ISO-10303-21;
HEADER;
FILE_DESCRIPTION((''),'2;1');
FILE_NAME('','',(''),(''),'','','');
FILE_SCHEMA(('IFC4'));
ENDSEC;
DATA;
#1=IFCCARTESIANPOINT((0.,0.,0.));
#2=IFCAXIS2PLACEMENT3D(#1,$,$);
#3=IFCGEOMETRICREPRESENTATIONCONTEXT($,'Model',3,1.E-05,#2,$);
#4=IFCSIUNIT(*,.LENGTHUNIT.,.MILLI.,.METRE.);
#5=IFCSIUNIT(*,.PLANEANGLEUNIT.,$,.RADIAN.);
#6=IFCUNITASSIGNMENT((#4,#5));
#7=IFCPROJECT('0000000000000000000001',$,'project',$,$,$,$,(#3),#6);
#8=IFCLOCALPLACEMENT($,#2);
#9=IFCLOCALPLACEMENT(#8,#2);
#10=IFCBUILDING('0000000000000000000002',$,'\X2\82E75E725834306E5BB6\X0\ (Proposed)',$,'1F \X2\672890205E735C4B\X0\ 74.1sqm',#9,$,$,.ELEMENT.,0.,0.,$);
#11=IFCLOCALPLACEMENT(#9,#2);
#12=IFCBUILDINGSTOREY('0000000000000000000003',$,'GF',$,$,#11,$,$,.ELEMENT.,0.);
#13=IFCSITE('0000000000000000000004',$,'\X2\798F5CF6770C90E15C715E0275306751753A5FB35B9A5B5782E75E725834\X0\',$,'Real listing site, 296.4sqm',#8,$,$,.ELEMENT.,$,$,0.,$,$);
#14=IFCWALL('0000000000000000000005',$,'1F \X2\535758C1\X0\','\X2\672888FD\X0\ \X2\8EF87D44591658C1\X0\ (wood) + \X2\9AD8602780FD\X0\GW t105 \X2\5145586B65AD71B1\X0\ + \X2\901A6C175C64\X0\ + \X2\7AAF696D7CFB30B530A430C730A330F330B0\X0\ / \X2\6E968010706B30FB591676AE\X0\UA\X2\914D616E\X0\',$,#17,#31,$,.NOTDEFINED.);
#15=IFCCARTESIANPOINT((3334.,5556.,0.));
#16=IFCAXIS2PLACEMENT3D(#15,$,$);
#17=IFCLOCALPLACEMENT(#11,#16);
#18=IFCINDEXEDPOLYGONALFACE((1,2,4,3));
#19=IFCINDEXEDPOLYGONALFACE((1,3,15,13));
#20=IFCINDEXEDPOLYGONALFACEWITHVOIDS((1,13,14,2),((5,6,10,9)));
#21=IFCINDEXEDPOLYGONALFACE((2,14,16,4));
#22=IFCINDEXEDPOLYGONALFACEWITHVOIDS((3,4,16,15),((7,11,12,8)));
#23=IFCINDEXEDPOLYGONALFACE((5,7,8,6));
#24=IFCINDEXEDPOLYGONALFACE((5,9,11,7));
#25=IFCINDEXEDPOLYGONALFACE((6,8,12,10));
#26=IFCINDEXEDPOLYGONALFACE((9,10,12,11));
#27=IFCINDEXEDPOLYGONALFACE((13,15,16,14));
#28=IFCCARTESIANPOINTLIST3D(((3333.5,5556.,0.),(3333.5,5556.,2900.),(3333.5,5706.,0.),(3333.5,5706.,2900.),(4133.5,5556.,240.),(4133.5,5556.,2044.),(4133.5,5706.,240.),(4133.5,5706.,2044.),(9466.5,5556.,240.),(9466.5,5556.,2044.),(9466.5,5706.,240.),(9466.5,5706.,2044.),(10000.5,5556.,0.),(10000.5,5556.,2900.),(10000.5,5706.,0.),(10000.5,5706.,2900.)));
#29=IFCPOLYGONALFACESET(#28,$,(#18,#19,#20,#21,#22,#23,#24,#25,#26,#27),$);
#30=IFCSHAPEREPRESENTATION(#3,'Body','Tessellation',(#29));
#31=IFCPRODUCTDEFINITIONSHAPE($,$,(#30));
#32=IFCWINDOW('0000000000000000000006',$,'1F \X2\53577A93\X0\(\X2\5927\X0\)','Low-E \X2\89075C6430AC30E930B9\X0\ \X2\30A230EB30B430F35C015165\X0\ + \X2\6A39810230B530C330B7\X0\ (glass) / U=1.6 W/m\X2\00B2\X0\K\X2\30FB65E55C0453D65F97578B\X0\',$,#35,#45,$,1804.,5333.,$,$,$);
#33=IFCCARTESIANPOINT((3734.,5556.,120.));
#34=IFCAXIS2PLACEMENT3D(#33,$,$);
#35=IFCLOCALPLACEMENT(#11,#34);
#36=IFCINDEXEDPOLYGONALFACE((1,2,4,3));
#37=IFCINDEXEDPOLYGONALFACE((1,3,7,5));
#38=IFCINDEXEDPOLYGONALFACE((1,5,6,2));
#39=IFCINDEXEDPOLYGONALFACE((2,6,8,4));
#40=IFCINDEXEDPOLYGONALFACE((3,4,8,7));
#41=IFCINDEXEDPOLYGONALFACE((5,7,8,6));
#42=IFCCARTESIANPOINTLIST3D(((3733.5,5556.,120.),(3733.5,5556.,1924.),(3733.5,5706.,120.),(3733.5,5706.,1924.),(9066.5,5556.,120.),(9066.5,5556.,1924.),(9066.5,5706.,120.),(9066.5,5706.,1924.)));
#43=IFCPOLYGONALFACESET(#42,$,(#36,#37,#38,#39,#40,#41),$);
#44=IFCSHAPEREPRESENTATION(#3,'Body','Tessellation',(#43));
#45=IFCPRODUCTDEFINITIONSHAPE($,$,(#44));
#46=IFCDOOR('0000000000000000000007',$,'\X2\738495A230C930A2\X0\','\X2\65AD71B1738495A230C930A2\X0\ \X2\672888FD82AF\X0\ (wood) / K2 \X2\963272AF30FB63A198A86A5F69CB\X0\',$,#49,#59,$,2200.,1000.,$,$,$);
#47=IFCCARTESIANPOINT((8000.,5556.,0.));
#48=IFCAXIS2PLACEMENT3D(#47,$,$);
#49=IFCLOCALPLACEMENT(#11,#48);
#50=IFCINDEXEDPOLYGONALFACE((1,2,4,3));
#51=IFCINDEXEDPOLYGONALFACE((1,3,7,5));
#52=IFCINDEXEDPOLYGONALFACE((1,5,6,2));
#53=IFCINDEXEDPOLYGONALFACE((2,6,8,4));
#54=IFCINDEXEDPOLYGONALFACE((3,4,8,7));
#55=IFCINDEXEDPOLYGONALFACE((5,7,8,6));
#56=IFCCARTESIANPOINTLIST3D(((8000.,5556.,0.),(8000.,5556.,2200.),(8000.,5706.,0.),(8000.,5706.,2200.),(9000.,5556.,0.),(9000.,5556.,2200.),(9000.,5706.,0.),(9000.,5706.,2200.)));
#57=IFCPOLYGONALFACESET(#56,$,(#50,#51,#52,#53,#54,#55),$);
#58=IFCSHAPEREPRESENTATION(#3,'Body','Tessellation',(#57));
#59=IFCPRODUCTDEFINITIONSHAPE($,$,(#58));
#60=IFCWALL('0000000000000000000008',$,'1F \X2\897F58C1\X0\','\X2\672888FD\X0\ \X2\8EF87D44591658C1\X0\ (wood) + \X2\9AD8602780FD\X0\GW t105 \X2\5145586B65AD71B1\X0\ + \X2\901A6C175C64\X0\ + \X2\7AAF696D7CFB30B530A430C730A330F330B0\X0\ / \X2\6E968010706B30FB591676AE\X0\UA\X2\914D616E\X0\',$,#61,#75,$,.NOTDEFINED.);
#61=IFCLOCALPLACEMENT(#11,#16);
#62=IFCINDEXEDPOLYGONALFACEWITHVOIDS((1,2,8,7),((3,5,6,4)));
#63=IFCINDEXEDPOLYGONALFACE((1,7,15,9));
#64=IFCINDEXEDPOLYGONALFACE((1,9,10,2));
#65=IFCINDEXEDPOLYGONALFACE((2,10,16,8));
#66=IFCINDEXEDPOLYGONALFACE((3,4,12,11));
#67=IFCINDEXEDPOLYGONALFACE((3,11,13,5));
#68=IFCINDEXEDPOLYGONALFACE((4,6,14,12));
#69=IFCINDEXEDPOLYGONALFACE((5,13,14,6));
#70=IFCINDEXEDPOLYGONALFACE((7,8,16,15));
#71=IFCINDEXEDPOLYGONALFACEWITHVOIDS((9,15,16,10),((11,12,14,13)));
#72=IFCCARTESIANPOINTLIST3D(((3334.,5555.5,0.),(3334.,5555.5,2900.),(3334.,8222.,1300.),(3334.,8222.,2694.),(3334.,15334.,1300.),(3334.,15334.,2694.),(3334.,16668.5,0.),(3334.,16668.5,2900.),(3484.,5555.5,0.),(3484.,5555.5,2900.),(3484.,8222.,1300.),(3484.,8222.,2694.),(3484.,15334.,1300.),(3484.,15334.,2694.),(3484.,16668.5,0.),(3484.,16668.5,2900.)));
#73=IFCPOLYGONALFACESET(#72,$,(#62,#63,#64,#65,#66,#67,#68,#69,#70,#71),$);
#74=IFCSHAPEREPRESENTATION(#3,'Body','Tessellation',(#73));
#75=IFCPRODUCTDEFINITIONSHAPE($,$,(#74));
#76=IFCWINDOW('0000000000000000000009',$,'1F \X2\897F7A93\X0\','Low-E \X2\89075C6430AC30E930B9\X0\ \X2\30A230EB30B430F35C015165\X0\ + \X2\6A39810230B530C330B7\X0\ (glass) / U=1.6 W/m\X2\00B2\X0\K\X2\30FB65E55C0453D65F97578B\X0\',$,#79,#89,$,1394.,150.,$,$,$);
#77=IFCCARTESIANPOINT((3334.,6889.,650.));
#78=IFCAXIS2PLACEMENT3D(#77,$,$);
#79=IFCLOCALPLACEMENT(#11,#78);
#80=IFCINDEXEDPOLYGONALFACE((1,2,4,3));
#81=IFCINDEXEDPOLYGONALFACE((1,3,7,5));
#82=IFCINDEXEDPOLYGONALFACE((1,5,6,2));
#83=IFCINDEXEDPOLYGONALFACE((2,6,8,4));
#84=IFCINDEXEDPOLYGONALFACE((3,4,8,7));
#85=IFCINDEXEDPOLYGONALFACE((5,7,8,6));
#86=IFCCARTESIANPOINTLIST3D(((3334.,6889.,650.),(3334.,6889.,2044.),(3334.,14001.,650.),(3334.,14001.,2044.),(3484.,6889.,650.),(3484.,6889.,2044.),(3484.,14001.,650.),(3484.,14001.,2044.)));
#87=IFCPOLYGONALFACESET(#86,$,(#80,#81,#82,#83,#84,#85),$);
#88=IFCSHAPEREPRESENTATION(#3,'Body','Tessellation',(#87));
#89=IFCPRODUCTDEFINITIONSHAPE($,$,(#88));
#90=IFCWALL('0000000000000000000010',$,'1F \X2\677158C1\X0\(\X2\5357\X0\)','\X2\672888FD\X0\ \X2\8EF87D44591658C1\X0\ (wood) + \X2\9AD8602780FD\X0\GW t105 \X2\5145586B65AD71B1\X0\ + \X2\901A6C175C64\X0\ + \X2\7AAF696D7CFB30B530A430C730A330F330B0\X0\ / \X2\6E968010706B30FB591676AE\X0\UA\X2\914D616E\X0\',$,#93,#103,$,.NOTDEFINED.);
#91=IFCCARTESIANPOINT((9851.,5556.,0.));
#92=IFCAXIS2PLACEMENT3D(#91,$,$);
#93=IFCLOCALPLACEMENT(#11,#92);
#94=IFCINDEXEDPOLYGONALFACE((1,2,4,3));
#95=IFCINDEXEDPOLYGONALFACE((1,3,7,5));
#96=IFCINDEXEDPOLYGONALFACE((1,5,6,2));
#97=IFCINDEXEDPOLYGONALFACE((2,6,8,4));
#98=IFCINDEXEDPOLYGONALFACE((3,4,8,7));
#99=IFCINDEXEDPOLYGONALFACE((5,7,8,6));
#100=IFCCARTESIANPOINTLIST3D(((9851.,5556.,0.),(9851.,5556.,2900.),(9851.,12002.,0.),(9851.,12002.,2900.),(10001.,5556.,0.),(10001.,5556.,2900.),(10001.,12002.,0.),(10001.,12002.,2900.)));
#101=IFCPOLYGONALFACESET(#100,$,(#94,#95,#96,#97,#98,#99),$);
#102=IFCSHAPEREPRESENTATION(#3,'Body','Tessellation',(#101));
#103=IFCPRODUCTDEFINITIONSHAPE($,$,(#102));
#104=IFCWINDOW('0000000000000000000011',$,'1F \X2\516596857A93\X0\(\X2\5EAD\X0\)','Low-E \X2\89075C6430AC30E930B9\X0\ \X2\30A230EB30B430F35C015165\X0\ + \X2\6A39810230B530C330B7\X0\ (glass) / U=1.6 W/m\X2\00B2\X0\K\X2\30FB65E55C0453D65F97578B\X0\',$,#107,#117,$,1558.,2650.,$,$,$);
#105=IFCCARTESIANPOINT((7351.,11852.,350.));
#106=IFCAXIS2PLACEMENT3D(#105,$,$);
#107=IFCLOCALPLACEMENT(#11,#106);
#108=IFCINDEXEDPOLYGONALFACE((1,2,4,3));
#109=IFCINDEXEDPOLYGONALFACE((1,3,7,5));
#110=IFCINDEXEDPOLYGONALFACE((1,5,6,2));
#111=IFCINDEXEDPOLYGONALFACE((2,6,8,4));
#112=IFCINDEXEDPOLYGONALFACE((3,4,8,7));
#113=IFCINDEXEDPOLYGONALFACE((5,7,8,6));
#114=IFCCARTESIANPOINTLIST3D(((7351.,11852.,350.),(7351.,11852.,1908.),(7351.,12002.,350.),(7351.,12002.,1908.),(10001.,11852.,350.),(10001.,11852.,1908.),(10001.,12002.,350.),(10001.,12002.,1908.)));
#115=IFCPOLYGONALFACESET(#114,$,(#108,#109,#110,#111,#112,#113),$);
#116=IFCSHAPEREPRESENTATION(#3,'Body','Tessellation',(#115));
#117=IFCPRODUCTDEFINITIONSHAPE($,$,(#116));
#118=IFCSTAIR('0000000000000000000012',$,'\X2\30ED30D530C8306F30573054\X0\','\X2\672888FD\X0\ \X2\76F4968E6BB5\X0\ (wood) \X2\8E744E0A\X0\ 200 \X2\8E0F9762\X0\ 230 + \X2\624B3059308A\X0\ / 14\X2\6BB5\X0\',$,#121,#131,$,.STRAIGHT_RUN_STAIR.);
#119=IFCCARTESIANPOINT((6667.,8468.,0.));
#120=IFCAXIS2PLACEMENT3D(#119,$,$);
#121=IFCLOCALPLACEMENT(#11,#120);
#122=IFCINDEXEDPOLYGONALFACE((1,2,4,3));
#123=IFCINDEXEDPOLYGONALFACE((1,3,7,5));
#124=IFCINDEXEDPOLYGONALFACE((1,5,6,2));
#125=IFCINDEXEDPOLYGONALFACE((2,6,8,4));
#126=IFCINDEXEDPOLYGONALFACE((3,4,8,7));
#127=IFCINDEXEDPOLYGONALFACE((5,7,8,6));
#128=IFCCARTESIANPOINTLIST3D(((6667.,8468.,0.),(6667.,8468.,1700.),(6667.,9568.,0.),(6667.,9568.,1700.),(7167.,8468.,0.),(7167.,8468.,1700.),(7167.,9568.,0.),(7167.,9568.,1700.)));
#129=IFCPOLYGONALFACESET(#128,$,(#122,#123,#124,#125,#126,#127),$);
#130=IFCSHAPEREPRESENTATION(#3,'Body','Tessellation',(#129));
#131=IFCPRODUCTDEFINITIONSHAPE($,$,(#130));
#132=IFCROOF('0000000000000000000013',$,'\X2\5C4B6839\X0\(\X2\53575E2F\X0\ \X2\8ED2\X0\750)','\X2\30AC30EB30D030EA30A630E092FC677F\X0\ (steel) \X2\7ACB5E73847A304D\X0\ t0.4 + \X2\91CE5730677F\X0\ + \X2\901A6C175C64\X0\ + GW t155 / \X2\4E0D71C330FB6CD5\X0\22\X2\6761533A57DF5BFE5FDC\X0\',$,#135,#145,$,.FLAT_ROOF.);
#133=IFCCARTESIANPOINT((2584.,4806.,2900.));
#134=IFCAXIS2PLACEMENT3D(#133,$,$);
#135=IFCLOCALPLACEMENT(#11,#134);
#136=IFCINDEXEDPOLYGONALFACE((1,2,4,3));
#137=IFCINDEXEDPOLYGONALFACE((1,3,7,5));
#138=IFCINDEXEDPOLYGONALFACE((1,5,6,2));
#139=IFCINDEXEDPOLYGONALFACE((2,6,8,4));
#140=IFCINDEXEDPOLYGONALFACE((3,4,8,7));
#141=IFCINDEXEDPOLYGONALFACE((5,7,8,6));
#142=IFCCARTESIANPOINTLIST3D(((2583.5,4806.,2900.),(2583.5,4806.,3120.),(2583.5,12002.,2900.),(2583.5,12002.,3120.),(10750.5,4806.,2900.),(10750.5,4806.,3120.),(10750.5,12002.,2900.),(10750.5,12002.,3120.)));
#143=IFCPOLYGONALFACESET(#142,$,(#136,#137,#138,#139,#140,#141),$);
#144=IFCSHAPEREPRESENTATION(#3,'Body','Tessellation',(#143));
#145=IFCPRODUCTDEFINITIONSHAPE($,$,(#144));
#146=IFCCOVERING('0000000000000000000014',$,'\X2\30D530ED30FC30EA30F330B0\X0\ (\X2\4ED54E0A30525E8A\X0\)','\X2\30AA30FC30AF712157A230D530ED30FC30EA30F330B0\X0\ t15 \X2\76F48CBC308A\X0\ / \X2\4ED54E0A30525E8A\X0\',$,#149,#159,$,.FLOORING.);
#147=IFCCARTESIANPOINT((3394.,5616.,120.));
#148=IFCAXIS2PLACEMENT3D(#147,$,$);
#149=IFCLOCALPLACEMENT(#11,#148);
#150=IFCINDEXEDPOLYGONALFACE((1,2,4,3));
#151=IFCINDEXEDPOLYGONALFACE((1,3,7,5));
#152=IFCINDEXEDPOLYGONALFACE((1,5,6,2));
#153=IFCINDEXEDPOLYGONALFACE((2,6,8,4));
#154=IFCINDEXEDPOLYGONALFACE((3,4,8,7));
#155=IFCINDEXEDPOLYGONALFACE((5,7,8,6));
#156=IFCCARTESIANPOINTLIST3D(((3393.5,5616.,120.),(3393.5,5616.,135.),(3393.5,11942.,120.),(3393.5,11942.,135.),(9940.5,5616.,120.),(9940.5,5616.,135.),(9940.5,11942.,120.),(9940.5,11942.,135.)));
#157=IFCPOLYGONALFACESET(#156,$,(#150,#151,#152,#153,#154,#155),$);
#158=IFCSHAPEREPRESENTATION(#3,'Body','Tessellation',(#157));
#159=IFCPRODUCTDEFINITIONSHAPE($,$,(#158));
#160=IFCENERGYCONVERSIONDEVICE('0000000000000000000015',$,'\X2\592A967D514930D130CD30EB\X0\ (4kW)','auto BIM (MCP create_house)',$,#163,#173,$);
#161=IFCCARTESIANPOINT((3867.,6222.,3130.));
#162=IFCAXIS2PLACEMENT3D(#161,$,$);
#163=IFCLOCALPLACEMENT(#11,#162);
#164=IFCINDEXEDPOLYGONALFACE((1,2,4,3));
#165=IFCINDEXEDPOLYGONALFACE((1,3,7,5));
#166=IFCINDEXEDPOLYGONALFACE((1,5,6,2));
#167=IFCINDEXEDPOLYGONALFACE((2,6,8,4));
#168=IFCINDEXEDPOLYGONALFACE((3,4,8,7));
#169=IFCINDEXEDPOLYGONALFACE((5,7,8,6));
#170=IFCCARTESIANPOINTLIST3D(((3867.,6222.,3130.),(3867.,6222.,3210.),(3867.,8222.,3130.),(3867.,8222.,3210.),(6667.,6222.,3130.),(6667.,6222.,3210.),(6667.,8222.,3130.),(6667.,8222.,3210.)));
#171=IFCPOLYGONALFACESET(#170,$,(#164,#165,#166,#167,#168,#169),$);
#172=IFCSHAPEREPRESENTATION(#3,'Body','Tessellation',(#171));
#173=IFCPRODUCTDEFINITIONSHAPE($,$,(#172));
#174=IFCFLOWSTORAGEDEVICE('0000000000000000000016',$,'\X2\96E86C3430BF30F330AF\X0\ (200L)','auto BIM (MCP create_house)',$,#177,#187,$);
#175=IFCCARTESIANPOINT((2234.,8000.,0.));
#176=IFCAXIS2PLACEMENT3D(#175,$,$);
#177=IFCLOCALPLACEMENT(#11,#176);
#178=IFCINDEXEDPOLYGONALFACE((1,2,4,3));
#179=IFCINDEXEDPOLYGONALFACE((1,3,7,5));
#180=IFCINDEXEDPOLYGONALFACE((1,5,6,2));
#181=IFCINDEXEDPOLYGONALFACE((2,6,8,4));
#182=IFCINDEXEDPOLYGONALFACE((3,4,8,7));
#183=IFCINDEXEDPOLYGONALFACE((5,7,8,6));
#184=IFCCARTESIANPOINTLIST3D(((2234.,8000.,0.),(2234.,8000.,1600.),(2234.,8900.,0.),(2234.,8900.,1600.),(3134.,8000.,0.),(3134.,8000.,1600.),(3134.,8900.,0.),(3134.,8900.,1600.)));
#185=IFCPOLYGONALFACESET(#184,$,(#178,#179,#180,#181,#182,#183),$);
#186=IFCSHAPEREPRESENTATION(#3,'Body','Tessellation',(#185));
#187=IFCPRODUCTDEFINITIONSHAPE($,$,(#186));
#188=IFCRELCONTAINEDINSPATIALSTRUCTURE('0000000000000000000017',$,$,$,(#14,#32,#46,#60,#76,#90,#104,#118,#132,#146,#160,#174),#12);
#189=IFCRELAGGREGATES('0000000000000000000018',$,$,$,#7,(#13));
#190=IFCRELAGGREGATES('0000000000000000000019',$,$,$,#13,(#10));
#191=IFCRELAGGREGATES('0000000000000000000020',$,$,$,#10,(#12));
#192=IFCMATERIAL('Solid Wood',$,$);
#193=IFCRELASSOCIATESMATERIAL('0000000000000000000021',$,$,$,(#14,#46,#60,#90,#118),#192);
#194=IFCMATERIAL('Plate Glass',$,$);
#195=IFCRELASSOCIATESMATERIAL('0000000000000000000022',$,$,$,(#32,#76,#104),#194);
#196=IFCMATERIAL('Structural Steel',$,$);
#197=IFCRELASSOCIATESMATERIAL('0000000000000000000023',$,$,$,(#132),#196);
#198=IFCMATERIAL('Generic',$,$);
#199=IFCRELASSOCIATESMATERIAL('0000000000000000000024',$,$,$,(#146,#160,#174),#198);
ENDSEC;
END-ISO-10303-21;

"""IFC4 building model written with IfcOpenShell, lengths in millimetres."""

from ifc_helpers import new_model, si_unit, frame, frame_2d, origin, place, context, project, spatial, rectangle, extrude, material, element, fill, save


model = new_model("IFC4")

# Units and contexts
model_context = context("Model", 3, precision=1e-05, world=origin())
ifc_project = project(units=[si_unit("LENGTHUNIT", "METRE", prefix="MILLI"), si_unit("PLANEANGLEUNIT", "RADIAN")], contexts=[model_context])

# Site, building, storey
site_placement = place(None, origin())
site = spatial("IfcSite", under=ifc_project, at=site_placement, Name="福島県郡山市田村町徳定字苧干場", ObjectType="Real listing site, 296.4sqm", CompositionType="ELEMENT", RefElevation=0.0)
building_placement = place(site_placement, origin())
building = spatial("IfcBuilding", under=site, at=building_placement, Name="苧干場の家 (Proposed)", ObjectType="1F 木造平屋 74.1sqm", CompositionType="ELEMENT", ElevationOfRefHeight=0.0, ElevationOfTerrain=0.0)
storey_placement = place(building_placement, origin())
storey = spatial("IfcBuildingStorey", under=building, at=storey_placement, Name="GF", CompositionType="ELEMENT", Elevation=0.0)

# Shared definitions
ifc_material_1 = material(Name="Solid Wood")

# Wall, openings, window, door
wall_1_placement = place(storey_placement, frame((3334.0, 5556.0, 0.0)))
wall_1 = element("IfcWall", 1, at=wall_1_placement, inside=storey, material=ifc_material_1, Name="1F 南壁", Description="木製 軸組外壁 (wood) + 高性能GW t105 充填断熱 + 通気層 + 窯業系サイディング / 準耐火・外皮UA配慮", PredefinedType="NOTDEFINED", context=model_context, shape_type="SweptSolid", body=[
    extrude(rectangle(XDim=6667.0, YDim=150.0, at=frame_2d((3333.0, 75.0))), frame((3334.0, 5556.0, 0.0)), (0.0, 0.0, 1.0), 2900.0),
])
opening_1_placement = place(storey_placement, frame((3734.0, 5556.0, 120.0)))
opening_1 = element("IfcOpeningElement", 2, at=opening_1_placement, cuts=wall_1, PredefinedType="NOTDEFINED", context=model_context, shape_type="SweptSolid", body=[
    extrude(rectangle(XDim=5333.0, YDim=150.0, at=frame_2d((2666.0, 75.0))), frame((3734.0, 5556.0, 120.0)), (0.0, 0.0, 1.0), 1804.0),
])
opening_2_placement = place(storey_placement, frame((8000.0, 5556.0, 0.0)))
opening_2 = element("IfcOpeningElement", 3, at=opening_2_placement, cuts=wall_1, PredefinedType="NOTDEFINED", context=model_context, shape_type="SweptSolid", body=[
    extrude(rectangle(XDim=1000.0, YDim=150.0, at=frame_2d((500.0, 75.0))), frame((8000.0, 5556.0, 0.0)), (0.0, 0.0, 1.0), 2200.0),
])
ifc_material_2 = material(Name="Plate Glass")
window_1_placement = place(storey_placement, frame((3734.0, 5556.0, 120.0)))
window_1 = element("IfcWindow", 4, at=window_1_placement, inside=storey, material=ifc_material_2, Name="1F 南窓(大)", Description="Low-E 複層ガラス アルゴン封入 + 樹脂サッシ (glass) / U=1.6 W/m²K・日射取得型", OverallHeight=1804.0, OverallWidth=5333.0, context=model_context, shape_type="SweptSolid", body=[
    extrude(rectangle(XDim=5333.0, YDim=150.0, at=frame_2d((2666.0, 75.0))), frame((3734.0, 5556.0, 120.0)), (0.0, 0.0, 1.0), 1804.0),
])
fill(opening_1, window_1)
door_1_placement = place(storey_placement, frame((8000.0, 5556.0, 0.0)))
door_1 = element("IfcDoor", 5, at=door_1_placement, inside=storey, material=ifc_material_1, Name="玄関ドア", Description="断熱玄関ドア 木製芯 (wood) / K2 防犯・採風機構", OverallHeight=2200.0, OverallWidth=1000.0, context=model_context, shape_type="SweptSolid", body=[
    extrude(rectangle(XDim=1000.0, YDim=150.0, at=frame_2d((500.0, 75.0))), frame((8000.0, 5556.0, 0.0)), (0.0, 0.0, 1.0), 2200.0),
])
fill(opening_2, door_1)

# Walls, openings, windows
wall_2_placement = place(storey_placement, frame((3334.0, 5556.0, 0.0)))
wall_2 = element("IfcWall", 6, at=wall_2_placement, inside=storey, material=ifc_material_1, Name="1F 西壁", Description="木製 軸組外壁 (wood) + 高性能GW t105 充填断熱 + 通気層 + 窯業系サイディング / 準耐火・外皮UA配慮", PredefinedType="NOTDEFINED", context=model_context, shape_type="SweptSolid", body=[
    extrude(rectangle(XDim=150.0, YDim=11113.0, at=frame_2d((75.0, 5556.0))), frame((3334.0, 5556.0, 0.0)), (0.0, 0.0, 1.0), 2900.0),
])
opening_3_placement = place(storey_placement, frame((3334.0, 6889.0, 650.0)))
opening_3 = element("IfcOpeningElement", 7, at=opening_3_placement, cuts=wall_2, PredefinedType="NOTDEFINED", context=model_context, shape_type="SweptSolid", body=[
    extrude(rectangle(XDim=150.0, YDim=7112.0, at=frame_2d((75.0, 3556.0))), frame((3334.0, 6889.0, 650.0)), (0.0, 0.0, 1.0), 1394.0),
])
window_2_placement = place(storey_placement, frame((3334.0, 6889.0, 650.0)))
window_2 = element("IfcWindow", 8, at=window_2_placement, inside=storey, material=ifc_material_2, Name="1F 西窓", Description="Low-E 複層ガラス アルゴン封入 + 樹脂サッシ (glass) / U=1.6 W/m²K・日射取得型", OverallHeight=1394.0, OverallWidth=150.0, context=model_context, shape_type="SweptSolid", body=[
    extrude(rectangle(XDim=150.0, YDim=7112.0, at=frame_2d((75.0, 3556.0))), frame((3334.0, 6889.0, 650.0)), (0.0, 0.0, 1.0), 1394.0),
])
fill(opening_3, window_2)
wall_3_placement = place(storey_placement, frame((9851.0, 5556.0, 0.0)))
wall_3 = element("IfcWall", 9, at=wall_3_placement, inside=storey, material=ifc_material_1, Name="1F 東壁(南)", Description="木製 軸組外壁 (wood) + 高性能GW t105 充填断熱 + 通気層 + 窯業系サイディング / 準耐火・外皮UA配慮", PredefinedType="NOTDEFINED", context=model_context, shape_type="SweptSolid", body=[
    extrude(rectangle(XDim=150.0, YDim=6446.0, at=frame_2d((75.0, 3223.0))), frame((9851.0, 5556.0, 0.0)), (0.0, 0.0, 1.0), 2900.0),
])
opening_4_placement = place(storey_placement, frame((7351.0, 11852.0, 350.0)))
opening_4 = element("IfcOpeningElement", 10, at=opening_4_placement, cuts=wall_3, PredefinedType="NOTDEFINED", context=model_context, shape_type="SweptSolid", body=[
    extrude(rectangle(XDim=2650.0, YDim=150.0, at=frame_2d((1325.0, 75.0))), frame((7351.0, 11852.0, 350.0)), (0.0, 0.0, 1.0), 1558.0),
])
window_3_placement = place(storey_placement, frame((7351.0, 11852.0, 350.0)))
window_3 = element("IfcWindow", 11, at=window_3_placement, inside=storey, material=ifc_material_2, Name="1F 入隅窓(庭)", Description="Low-E 複層ガラス アルゴン封入 + 樹脂サッシ (glass) / U=1.6 W/m²K・日射取得型", OverallHeight=1558.0, OverallWidth=2650.0, context=model_context, shape_type="SweptSolid", body=[
    extrude(rectangle(XDim=2650.0, YDim=150.0, at=frame_2d((1325.0, 75.0))), frame((7351.0, 11852.0, 350.0)), (0.0, 0.0, 1.0), 1558.0),
])
fill(opening_4, window_3)

# Stair
stair_placement = place(storey_placement, frame((6667.0, 8468.0, 0.0)))
element("IfcStair", 12, at=stair_placement, inside=storey, material=ifc_material_1, Name="ロフトはしご", Description="木製 直階段 (wood) 蹴上 200 踏面 230 + 手すり / 14段", PredefinedType="STRAIGHT_RUN_STAIR", context=model_context, shape_type="SweptSolid", body=[
    extrude(rectangle(XDim=500.0, YDim=1100.0, at=frame_2d((250.0, 550.0))), frame((6667.0, 8468.0, 0.0)), (0.0, 0.0, 1.0), 1700.0),
])

# Roof
ifc_material_3 = material(Name="Structural Steel")
roof_placement = place(storey_placement, frame((2584.0, 4806.0, 2900.0)))
element("IfcRoof", 13, at=roof_placement, inside=storey, material=ifc_material_3, Name="屋根(南帯 軒750)", Description="ガルバリウム鋼板 (steel) 立平葺き t0.4 + 野地板 + 通気層 + GW t155 / 不燃・法22条区域対応", PredefinedType="FLAT_ROOF", context=model_context, shape_type="SweptSolid", body=[
    extrude(rectangle(XDim=8167.0, YDim=7196.0, at=frame_2d((4083.0, 3598.0))), frame((2584.0, 4806.0, 2900.0)), (0.0, 0.0, 1.0), 220.0),
])

# Covering
ifc_material_4 = material(Name="Generic")
covering_placement = place(storey_placement, frame((3394.0, 5616.0, 120.0)))
element("IfcCovering", 14, at=covering_placement, inside=storey, material=ifc_material_4, Name="フローリング (仕上げ床)", Description="オーク無垢フローリング t15 直貼り / 仕上げ床", PredefinedType="FLOORING", context=model_context, shape_type="SweptSolid", body=[
    extrude(rectangle(XDim=6547.0, YDim=6326.0, at=frame_2d((3273.0, 3163.0))), frame((3394.0, 5616.0, 120.0)), (0.0, 0.0, 1.0), 15.0),
])

# Energy conversion device
energy_conversion_device_placement = place(storey_placement, frame((3867.0, 6222.0, 3130.0)))
element("IfcEnergyConversionDevice", 15, at=energy_conversion_device_placement, inside=storey, material=ifc_material_4, Name="太陽光パネル (4kW)", Description="auto BIM (MCP create_house)", context=model_context, shape_type="SweptSolid", body=[
    extrude(rectangle(XDim=2800.0, YDim=2000.0, at=frame_2d((1400.0, 1000.0))), frame((3867.0, 6222.0, 3130.0)), (0.0, 0.0, 1.0), 80.0),
])

# Flow storage device
flow_storage_device_placement = place(storey_placement, frame((2234.0, 8000.0, 0.0)))
element("IfcFlowStorageDevice", 16, at=flow_storage_device_placement, inside=storey, material=ifc_material_4, Name="雨水タンク (200L)", Description="auto BIM (MCP create_house)", context=model_context, shape_type="SweptSolid", body=[
    extrude(rectangle(XDim=900.0, YDim=900.0, at=frame_2d((450.0, 450.0))), frame((2234.0, 8000.0, 0.0)), (0.0, 0.0, 1.0), 1600.0),
])

save(model, "model.ifc")
